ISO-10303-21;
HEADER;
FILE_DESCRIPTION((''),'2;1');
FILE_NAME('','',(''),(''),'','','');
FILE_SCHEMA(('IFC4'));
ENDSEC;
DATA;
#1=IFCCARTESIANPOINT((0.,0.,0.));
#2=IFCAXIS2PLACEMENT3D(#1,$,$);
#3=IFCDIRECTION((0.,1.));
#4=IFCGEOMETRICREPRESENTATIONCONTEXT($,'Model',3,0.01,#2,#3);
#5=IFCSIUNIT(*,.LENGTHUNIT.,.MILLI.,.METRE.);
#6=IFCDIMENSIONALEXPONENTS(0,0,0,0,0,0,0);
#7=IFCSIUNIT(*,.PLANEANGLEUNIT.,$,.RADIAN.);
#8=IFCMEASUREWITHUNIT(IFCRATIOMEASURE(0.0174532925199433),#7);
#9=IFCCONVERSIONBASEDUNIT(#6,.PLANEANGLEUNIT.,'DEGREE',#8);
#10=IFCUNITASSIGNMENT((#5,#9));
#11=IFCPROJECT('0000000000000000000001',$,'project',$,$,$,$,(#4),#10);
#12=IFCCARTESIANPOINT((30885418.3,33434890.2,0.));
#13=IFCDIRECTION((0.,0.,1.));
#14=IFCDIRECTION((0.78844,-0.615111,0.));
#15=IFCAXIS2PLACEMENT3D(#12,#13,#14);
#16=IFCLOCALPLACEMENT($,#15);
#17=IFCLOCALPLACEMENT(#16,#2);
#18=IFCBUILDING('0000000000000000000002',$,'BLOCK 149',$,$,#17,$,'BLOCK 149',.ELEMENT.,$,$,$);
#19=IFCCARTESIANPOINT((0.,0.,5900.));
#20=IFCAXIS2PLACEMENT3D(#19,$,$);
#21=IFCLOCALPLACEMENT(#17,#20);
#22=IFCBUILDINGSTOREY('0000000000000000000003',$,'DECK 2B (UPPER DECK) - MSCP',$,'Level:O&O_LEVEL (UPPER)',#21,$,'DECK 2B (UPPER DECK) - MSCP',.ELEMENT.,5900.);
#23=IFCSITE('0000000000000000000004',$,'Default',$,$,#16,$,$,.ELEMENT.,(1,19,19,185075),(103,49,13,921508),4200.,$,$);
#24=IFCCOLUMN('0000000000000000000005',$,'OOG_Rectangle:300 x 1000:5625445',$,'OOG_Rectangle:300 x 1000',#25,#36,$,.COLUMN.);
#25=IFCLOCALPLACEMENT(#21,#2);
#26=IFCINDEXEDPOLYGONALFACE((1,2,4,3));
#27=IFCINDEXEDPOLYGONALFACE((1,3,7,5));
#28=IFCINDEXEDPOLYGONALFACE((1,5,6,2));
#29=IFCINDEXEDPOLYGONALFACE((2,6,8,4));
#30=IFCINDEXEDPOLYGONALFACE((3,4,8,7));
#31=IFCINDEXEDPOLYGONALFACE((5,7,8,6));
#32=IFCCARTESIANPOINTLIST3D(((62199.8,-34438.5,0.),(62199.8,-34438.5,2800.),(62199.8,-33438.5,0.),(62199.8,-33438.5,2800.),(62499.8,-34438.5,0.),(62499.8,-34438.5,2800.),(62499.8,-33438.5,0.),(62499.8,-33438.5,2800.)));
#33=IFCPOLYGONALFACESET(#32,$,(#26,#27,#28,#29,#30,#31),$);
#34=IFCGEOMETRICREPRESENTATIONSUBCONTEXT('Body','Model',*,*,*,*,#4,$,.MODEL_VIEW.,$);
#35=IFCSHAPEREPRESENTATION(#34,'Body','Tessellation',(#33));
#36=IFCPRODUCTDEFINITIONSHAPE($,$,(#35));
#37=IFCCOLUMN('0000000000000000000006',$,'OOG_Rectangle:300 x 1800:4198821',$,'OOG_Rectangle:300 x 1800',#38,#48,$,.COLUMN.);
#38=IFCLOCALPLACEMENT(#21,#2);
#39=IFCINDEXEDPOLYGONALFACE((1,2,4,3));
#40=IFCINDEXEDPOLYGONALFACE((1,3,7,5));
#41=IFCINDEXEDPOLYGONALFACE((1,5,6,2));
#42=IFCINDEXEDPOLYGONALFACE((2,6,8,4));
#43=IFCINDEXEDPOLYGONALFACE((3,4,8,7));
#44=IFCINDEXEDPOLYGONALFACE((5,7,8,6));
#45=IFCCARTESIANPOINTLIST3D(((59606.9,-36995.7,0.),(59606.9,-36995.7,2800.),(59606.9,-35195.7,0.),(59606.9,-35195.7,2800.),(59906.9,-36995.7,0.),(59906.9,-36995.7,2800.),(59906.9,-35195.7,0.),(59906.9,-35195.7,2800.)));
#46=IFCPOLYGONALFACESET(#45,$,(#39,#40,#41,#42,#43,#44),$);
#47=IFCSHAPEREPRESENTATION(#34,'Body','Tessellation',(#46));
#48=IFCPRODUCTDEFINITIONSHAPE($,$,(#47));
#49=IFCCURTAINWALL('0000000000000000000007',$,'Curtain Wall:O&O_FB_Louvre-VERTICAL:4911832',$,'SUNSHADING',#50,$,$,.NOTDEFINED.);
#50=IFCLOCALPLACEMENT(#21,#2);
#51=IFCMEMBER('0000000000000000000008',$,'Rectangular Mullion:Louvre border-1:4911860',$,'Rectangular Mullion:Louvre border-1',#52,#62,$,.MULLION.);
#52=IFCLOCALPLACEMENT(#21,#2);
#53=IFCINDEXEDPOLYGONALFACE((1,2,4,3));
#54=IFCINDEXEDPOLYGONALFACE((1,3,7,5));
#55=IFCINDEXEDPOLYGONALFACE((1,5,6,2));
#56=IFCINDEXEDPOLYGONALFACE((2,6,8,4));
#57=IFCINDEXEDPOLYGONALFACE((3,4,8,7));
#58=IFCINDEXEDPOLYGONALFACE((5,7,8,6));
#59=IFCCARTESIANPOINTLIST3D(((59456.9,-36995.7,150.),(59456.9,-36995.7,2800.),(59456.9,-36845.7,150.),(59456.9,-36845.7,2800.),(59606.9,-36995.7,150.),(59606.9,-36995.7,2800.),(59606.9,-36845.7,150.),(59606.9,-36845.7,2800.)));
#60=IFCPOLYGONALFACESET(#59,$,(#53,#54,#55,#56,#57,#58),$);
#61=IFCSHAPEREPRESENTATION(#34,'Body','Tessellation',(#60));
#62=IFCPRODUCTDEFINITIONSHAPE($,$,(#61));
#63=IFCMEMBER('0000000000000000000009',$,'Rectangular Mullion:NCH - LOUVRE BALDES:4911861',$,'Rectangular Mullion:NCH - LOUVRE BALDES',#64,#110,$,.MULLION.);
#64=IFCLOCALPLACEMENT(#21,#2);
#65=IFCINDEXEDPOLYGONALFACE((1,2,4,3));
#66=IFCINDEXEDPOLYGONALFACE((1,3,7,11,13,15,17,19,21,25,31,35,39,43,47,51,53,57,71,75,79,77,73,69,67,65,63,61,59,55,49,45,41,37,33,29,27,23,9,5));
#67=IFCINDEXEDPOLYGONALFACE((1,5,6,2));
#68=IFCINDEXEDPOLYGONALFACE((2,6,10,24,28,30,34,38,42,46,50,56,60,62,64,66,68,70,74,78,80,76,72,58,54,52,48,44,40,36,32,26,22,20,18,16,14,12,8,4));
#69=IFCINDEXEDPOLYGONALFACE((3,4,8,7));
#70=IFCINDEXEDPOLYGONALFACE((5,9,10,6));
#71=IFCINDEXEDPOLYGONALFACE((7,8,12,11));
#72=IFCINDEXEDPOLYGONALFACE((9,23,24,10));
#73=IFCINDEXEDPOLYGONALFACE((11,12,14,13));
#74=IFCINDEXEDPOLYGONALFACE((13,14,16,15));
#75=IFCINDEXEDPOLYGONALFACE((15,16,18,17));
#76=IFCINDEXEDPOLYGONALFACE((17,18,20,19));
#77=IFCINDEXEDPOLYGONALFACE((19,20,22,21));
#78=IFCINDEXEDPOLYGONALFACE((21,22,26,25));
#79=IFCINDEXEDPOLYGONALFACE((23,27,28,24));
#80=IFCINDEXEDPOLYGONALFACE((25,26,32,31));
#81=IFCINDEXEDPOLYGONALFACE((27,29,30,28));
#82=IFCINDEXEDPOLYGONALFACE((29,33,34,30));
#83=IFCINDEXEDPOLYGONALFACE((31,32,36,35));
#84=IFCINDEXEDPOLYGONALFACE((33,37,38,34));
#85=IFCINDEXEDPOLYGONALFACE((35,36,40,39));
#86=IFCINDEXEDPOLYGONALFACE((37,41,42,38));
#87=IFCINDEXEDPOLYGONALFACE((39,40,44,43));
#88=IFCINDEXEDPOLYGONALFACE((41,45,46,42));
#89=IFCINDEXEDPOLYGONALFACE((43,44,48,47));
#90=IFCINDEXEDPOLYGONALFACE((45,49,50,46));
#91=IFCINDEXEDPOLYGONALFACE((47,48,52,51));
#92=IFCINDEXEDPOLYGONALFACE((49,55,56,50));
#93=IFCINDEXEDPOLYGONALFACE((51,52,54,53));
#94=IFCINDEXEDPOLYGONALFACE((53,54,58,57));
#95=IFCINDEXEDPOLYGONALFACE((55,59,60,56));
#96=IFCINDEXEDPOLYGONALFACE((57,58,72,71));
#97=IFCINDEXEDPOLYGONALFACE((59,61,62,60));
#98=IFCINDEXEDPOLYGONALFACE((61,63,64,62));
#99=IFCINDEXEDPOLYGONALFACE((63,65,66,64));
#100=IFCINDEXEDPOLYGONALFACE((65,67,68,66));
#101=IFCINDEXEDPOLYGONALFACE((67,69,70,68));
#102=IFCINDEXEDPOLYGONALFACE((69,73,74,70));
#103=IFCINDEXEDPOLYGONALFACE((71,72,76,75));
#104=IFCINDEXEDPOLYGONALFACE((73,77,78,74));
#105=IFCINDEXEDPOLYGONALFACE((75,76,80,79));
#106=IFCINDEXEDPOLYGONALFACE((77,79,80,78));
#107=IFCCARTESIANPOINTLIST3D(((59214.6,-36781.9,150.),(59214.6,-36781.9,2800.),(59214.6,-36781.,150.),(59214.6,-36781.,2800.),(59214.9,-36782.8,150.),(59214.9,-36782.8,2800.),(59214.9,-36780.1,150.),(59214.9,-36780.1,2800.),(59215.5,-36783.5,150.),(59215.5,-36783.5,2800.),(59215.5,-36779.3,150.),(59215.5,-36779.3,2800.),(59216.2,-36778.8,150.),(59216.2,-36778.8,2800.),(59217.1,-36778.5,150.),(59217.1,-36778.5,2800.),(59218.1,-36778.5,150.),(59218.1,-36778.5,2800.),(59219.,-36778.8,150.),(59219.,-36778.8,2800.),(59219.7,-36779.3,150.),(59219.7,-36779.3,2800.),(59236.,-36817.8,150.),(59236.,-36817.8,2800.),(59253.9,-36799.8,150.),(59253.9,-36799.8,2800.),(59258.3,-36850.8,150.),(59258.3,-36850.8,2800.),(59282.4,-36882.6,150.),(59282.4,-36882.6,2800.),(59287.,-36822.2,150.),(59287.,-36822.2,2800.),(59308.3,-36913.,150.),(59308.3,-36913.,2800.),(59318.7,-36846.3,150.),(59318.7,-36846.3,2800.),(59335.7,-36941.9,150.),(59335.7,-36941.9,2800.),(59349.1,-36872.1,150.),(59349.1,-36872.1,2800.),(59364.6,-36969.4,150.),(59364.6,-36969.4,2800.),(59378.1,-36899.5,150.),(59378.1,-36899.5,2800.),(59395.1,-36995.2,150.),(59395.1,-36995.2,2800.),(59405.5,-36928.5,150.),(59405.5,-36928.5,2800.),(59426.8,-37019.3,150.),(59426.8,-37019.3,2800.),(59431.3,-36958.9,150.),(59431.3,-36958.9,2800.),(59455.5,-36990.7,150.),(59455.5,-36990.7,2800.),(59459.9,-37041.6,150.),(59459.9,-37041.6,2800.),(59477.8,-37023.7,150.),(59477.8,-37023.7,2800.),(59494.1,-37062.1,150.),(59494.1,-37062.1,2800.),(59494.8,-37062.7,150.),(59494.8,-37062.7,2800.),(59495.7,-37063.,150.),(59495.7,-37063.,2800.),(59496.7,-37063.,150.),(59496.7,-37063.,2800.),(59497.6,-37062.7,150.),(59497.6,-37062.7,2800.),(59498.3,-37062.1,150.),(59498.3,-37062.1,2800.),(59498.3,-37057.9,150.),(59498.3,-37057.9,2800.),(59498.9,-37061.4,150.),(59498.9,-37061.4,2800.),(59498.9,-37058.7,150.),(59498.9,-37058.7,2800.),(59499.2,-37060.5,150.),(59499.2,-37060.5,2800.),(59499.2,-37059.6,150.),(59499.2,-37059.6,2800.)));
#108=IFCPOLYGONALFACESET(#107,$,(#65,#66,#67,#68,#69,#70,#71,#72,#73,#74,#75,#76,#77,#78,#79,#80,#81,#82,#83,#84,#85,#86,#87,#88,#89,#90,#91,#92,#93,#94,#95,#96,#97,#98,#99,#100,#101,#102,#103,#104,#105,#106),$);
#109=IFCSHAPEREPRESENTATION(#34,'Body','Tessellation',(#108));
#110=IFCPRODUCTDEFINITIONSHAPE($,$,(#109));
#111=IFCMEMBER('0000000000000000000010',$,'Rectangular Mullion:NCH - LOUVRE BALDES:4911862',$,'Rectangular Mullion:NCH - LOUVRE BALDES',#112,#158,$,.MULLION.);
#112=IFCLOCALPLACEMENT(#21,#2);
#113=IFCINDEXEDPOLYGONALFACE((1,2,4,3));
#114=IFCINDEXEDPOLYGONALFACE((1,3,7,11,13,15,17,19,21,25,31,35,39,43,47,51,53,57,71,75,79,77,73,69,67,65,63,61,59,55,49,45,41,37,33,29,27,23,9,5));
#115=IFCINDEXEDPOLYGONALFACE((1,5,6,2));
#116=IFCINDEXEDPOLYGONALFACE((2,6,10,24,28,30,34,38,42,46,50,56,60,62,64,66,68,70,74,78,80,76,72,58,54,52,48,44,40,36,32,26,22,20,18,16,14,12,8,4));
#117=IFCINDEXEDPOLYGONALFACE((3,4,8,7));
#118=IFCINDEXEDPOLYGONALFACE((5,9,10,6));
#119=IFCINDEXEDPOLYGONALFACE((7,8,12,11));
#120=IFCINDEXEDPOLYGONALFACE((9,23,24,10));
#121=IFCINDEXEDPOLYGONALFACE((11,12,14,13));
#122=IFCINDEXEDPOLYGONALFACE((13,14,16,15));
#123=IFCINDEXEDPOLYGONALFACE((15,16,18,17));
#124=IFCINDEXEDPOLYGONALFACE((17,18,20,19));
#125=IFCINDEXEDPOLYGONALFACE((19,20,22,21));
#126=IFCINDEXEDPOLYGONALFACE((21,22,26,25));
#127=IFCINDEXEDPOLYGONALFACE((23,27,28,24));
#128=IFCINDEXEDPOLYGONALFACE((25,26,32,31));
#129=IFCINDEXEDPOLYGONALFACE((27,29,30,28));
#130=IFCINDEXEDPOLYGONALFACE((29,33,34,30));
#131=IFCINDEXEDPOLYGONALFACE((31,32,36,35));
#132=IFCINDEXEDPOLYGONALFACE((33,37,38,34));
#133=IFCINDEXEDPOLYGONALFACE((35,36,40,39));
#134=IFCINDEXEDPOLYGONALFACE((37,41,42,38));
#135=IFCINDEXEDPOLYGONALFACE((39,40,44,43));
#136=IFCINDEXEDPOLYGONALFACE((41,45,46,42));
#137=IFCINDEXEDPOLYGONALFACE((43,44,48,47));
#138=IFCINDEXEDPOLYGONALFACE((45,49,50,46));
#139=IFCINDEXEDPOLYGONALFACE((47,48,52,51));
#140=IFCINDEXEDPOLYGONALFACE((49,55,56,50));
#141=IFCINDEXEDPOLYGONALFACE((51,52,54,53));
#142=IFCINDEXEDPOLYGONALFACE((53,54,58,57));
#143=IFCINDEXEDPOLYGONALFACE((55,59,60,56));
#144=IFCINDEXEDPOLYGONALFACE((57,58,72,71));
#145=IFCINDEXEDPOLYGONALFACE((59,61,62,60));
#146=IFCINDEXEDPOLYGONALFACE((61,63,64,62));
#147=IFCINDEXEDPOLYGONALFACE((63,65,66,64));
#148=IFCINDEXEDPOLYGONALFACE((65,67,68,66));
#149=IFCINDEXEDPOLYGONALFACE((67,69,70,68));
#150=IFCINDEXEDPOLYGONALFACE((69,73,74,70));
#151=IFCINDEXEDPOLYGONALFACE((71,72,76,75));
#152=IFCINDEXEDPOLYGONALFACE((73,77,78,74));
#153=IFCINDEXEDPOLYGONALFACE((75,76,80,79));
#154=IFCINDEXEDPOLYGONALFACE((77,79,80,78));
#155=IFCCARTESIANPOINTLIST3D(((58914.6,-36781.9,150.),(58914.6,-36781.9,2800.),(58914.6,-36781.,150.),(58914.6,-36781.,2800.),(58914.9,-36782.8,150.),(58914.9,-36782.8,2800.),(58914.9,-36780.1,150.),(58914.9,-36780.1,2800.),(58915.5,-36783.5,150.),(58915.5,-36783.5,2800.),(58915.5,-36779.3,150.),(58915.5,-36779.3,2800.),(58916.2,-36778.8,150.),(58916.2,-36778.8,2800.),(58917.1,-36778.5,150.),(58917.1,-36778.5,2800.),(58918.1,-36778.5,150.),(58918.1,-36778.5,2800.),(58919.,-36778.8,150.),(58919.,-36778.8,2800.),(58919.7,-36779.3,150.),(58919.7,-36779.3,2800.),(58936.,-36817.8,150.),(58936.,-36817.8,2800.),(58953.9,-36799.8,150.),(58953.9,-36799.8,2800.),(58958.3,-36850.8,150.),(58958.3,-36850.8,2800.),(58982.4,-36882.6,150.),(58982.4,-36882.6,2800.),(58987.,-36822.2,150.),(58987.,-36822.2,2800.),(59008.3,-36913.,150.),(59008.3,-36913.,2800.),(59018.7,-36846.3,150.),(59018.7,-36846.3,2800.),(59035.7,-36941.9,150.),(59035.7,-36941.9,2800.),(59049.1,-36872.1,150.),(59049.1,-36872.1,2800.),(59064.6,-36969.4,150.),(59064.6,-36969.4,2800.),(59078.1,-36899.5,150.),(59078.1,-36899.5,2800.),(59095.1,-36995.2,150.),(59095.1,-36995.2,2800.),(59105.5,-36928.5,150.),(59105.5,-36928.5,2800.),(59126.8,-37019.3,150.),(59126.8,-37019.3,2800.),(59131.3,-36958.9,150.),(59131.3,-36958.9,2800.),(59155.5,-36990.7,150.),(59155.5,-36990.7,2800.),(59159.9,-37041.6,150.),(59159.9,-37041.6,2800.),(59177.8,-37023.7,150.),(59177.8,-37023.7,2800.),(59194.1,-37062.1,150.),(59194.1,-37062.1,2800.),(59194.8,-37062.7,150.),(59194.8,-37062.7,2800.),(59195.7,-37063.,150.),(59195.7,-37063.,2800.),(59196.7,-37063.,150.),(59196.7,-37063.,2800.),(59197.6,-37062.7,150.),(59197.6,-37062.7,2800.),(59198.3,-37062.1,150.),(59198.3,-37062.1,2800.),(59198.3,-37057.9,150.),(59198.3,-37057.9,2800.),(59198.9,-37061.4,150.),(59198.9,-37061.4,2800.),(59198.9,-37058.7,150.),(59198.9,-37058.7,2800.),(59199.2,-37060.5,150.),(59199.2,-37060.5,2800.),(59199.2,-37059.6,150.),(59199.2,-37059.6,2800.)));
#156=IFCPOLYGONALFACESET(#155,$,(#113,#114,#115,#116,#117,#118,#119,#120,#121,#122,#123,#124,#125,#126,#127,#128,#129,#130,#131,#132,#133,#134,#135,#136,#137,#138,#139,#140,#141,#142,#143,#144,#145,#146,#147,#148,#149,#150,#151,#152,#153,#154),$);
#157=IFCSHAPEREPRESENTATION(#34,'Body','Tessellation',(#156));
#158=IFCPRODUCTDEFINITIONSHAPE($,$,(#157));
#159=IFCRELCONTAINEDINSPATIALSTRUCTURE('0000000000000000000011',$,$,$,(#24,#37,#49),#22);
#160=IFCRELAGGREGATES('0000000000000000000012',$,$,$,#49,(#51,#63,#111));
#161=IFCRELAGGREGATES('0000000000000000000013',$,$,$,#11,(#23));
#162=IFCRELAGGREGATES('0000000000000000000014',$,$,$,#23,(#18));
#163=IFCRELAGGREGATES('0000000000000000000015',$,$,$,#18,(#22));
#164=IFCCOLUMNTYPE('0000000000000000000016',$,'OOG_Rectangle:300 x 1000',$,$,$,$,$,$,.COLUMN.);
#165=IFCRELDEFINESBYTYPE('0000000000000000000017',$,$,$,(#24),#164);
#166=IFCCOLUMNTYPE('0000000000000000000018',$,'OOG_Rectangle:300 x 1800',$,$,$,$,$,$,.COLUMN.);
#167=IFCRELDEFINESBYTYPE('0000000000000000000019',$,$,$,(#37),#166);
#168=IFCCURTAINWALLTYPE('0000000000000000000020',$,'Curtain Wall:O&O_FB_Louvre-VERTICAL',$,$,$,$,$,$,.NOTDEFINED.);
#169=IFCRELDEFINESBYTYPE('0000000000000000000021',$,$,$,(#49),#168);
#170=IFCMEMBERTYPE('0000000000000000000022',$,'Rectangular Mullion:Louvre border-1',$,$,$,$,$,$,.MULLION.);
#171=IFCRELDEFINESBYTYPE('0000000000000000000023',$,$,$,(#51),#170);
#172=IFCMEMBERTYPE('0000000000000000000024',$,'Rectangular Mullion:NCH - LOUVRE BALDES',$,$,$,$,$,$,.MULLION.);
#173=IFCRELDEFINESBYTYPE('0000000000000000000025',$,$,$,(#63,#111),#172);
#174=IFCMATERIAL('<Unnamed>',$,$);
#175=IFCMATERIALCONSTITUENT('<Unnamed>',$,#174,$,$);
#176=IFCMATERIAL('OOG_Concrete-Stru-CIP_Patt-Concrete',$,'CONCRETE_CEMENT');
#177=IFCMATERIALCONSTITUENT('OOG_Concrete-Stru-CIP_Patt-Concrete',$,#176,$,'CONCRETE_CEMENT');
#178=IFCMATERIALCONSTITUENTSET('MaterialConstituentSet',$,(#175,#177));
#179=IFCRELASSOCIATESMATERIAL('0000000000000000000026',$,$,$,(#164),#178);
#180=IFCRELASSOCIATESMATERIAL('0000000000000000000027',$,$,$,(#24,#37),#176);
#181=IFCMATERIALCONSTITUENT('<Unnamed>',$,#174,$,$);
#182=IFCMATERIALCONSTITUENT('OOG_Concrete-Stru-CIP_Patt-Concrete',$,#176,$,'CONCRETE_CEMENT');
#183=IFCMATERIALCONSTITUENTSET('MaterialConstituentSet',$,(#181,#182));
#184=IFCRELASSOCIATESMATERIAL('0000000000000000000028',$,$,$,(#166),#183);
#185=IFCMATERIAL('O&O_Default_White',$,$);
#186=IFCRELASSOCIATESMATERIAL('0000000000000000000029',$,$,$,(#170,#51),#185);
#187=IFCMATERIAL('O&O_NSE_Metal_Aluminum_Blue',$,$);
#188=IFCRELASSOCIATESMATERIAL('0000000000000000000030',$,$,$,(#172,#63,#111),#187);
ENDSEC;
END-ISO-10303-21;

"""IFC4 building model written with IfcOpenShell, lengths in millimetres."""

from ifc_helpers import new_model, entity, si_unit, converted_unit, direction, frame, origin, place, context, subcontext, project, spatial, indexed_curve, outline, extrude, source, transform, mapped, material, constituent, constituent_set, type_object, type_shapes, element, aggregate, save


model = new_model("IFC4")

# Units and contexts
model_context = context("Model", 3, precision=0.01, world=origin(), true_north=direction((0.0, 1.0)))
body_context = subcontext(model_context, "Body", "Model", "MODEL_VIEW")
ifc_project = project(units=[si_unit("LENGTHUNIT", "METRE", prefix="MILLI"), converted_unit("PLANEANGLEUNIT", "DEGREE", entity("IfcRatioMeasure", 0.0174532925199433), si_unit("PLANEANGLEUNIT", "RADIAN"), dimensions=[0, 0, 0, 0, 0, 0, 0])], contexts=[model_context])

# Site, building, storey
site_placement = place(None, frame((30885418.3, 33434890.2, 0.0), z_axis=(0.0, 0.0, 1.0), x_axis=(0.78844, -0.615111, 0.0)))
site = spatial("IfcSite", under=ifc_project, at=site_placement, Name="Default", CompositionType="ELEMENT", RefLatitude=(1, 19, 19, 185075), RefLongitude=(103, 49, 13, 921508), RefElevation=4200.0)
building_placement = place(site_placement, origin())
building = spatial("IfcBuilding", under=site, at=building_placement, Name="BLOCK 149", LongName="BLOCK 149", CompositionType="ELEMENT")
storey_placement = place(building_placement, frame((0.0, 0.0, 5900.0)))
storey = spatial("IfcBuildingStorey", under=building, at=storey_placement, Name="DECK 2B (UPPER DECK) - MSCP", ObjectType="Level:O&O_LEVEL (UPPER)", LongName="DECK 2B (UPPER DECK) - MSCP", CompositionType="ELEMENT", Elevation=5900.0)

# Columns
ifc_material_1 = material(Name="OOG_Concrete-Stru-CIP_Patt-Concrete", Category="CONCRETE_CEMENT")
ifc_material_2 = material(Name="<Unnamed>")
ifc_constituent_1 = constituent(ifc_material_2, Name="<Unnamed>")
ifc_constituent_2 = constituent(ifc_material_1, Name="OOG_Concrete-Stru-CIP_Patt-Concrete", Category="CONCRETE_CEMENT")
ifc_constituent_set_1 = constituent_set(constituents=[ifc_constituent_1, ifc_constituent_2], Name="MaterialConstituentSet")
column_type_1 = type_object("IfcColumnType", Name="OOG_Rectangle:300 x 1000", PredefinedType="COLUMN", material=ifc_constituent_set_1)
shared_shape_1 = source(origin(), body_context, "Body", "SweptSolid", [
    extrude(outline(indexed_curve([(-500.0, -150.0), (500.0, -150.0), (500.0, 150.0), (-500.0, 150.0), (-500.0, -150.0)], self_intersect=False)), frame((0.0, 0.0, 5900.0), z_axis=(0.0, 0.0, 1.0), x_axis=(0.0, -1.0, 0.0)), (0.0, 0.0, 1.0), 2800.0),
])
type_shapes(column_type_1, [shared_shape_1])
column_1_placement = place(storey_placement, frame((62349.8, -33938.5, -5900.0)))
element("IfcColumn", 1, at=column_1_placement, inside=storey, type_object=column_type_1, material=ifc_material_1, Name="OOG_Rectangle:300 x 1000:5625445", ObjectType="OOG_Rectangle:300 x 1000", PredefinedType="COLUMN", context=body_context, shape_type="MappedRepresentation", body=[
    mapped(shared_shape_1, transform((0.0, 0.0, 0.0), scale=1.0)),
])
ifc_constituent_3 = constituent(ifc_material_2, Name="<Unnamed>")
ifc_constituent_4 = constituent(ifc_material_1, Name="OOG_Concrete-Stru-CIP_Patt-Concrete", Category="CONCRETE_CEMENT")
ifc_constituent_set_2 = constituent_set(constituents=[ifc_constituent_3, ifc_constituent_4], Name="MaterialConstituentSet")
column_type_2 = type_object("IfcColumnType", Name="OOG_Rectangle:300 x 1800", PredefinedType="COLUMN", material=ifc_constituent_set_2)
shared_shape_2 = source(origin(), body_context, "Body", "SweptSolid", [
    extrude(outline(indexed_curve([(-900.0, -150.0), (900.0, -150.0), (900.0, 150.0), (-900.0, 150.0), (-900.0, -150.0)], self_intersect=False)), frame((0.0, 0.0, 5900.0), z_axis=(0.0, 0.0, 1.0), x_axis=(0.0, -1.0, 0.0)), (0.0, 0.0, 1.0), 2800.0),
])
type_shapes(column_type_2, [shared_shape_2])
column_2_placement = place(storey_placement, frame((59756.9, -36095.7, -5900.0)))
element("IfcColumn", 2, at=column_2_placement, inside=storey, type_object=column_type_2, material=ifc_material_1, Name="OOG_Rectangle:300 x 1800:4198821", ObjectType="OOG_Rectangle:300 x 1800", PredefinedType="COLUMN", context=body_context, shape_type="MappedRepresentation", body=[
    mapped(shared_shape_2, transform((0.0, 0.0, 0.0), scale=1.0)),
])

# Curtain wall, members
curtain_wall_type = type_object("IfcCurtainWallType", Name="Curtain Wall:O&O_FB_Louvre-VERTICAL", PredefinedType="NOTDEFINED")
curtain_wall_placement = place(storey_placement, frame((0.0, 0.0, -5900.0)))
curtain_wall = element("IfcCurtainWall", 3, at=curtain_wall_placement, inside=storey, type_object=curtain_wall_type, Name="Curtain Wall:O&O_FB_Louvre-VERTICAL:4911832", ObjectType="SUNSHADING", PredefinedType="NOTDEFINED")
ifc_material_3 = material(Name="O&O_Default_White")
member_type_1 = type_object("IfcMemberType", Name="Rectangular Mullion:Louvre border-1", PredefinedType="MULLION", material=ifc_material_3)
shared_shape_3 = source(origin(), body_context, "Body", "SweptSolid", [
    extrude(outline(indexed_curve([(-75.0, -75.0), (75.0, -75.0), (75.0, 75.0), (-75.0, 75.0), (-75.0, -75.0)], self_intersect=False)), frame((-75.0, 0.0, -2650.0), z_axis=(0.0, 0.0, 1.0), x_axis=(0.0, -1.0, 0.0)), (0.0, 0.0, 1.0), 2650.0),
])
type_shapes(member_type_1, [shared_shape_3])
placement = place(building_placement, origin())
member_1_placement = place(placement, frame((59606.9, -36920.7, 8700.0)))
member_1 = element("IfcMember", 4, at=member_1_placement, type_object=member_type_1, material=ifc_material_3, Name="Rectangular Mullion:Louvre border-1:4911860", ObjectType="Rectangular Mullion:Louvre border-1", PredefinedType="MULLION", context=body_context, shape_type="MappedRepresentation", body=[
    mapped(shared_shape_3, transform((0.0, 0.0, 0.0), scale=1.0)),
])
ifc_material_4 = material(Name="O&O_NSE_Metal_Aluminum_Blue")
member_type_2 = type_object("IfcMemberType", Name="Rectangular Mullion:NCH - LOUVRE BALDES", PredefinedType="MULLION", material=ifc_material_4)
shared_shape_4 = source(origin(), body_context, "Body", "SweptSolid", [
    extrude(outline(indexed_curve([(55.9, -188.9), (54.8, -149.1), (51.6, -109.3), (46.1, -69.8), (38.6, -30.6), (28.9, 8.1), (17.1, 46.2), (3.3, 83.6), (-12.6, 120.2), (-30.4, 155.9), (-50.1, 190.5), (-50.5, 191.4), (-51.1, 192.1), (-52.0, 192.5), (-52.9, 192.7), (-53.8, 192.6), (-54.7, 192.2), (-55.4, 191.6), (-55.8, 190.8), (-56.0, 189.9), (-55.9, 188.9), (-54.8, 149.1), (-51.6, 109.3), (-46.1, 69.8), (-38.6, 30.6), (-28.9, -8.1), (-17.1, -46.2), (-3.3, -83.6), (12.6, -120.2), (30.4, -155.9), (50.1, -190.5), (50.5, -191.4), (51.1, -192.1), (52.0, -192.5), (52.9, -192.7), (53.8, -192.6), (54.7, -192.2), (55.4, -191.6), (55.8, -190.8), (56.0, -189.9), (55.9, -188.9)], self_intersect=False)), frame((0.0, 0.0, -2650.0), z_axis=(0.0, 0.0, 1.0), x_axis=(0.490779, -0.871284, 0.0)), (0.0, 0.0, 1.0), 2650.0),
])
type_shapes(member_type_2, [shared_shape_4])
member_2_placement = place(placement, frame((59356.9, -36920.7, 6050.0), z_axis=(0.0, 0.0, -1.0), x_axis=(-1.0, 0.0, 0.0)))
member_2 = element("IfcMember", 5, at=member_2_placement, type_object=member_type_2, material=ifc_material_4, Name="Rectangular Mullion:NCH - LOUVRE BALDES:4911861", ObjectType="Rectangular Mullion:NCH - LOUVRE BALDES", PredefinedType="MULLION", context=body_context, shape_type="MappedRepresentation", body=[
    mapped(shared_shape_4, transform((0.0, 0.0, 0.0), scale=1.0)),
])
member_3_placement = place(placement, frame((59056.9, -36920.7, 6050.0), z_axis=(0.0, 0.0, -1.0), x_axis=(-1.0, 0.0, 0.0)))
member_3 = element("IfcMember", 6, at=member_3_placement, type_object=member_type_2, material=ifc_material_4, Name="Rectangular Mullion:NCH - LOUVRE BALDES:4911862", ObjectType="Rectangular Mullion:NCH - LOUVRE BALDES", PredefinedType="MULLION", context=body_context, shape_type="MappedRepresentation", body=[
    mapped(shared_shape_4, transform((0.0, 0.0, 0.0), scale=1.0)),
])
aggregate(curtain_wall, [member_1, member_2, member_3])

save(model, "model.ifc")
